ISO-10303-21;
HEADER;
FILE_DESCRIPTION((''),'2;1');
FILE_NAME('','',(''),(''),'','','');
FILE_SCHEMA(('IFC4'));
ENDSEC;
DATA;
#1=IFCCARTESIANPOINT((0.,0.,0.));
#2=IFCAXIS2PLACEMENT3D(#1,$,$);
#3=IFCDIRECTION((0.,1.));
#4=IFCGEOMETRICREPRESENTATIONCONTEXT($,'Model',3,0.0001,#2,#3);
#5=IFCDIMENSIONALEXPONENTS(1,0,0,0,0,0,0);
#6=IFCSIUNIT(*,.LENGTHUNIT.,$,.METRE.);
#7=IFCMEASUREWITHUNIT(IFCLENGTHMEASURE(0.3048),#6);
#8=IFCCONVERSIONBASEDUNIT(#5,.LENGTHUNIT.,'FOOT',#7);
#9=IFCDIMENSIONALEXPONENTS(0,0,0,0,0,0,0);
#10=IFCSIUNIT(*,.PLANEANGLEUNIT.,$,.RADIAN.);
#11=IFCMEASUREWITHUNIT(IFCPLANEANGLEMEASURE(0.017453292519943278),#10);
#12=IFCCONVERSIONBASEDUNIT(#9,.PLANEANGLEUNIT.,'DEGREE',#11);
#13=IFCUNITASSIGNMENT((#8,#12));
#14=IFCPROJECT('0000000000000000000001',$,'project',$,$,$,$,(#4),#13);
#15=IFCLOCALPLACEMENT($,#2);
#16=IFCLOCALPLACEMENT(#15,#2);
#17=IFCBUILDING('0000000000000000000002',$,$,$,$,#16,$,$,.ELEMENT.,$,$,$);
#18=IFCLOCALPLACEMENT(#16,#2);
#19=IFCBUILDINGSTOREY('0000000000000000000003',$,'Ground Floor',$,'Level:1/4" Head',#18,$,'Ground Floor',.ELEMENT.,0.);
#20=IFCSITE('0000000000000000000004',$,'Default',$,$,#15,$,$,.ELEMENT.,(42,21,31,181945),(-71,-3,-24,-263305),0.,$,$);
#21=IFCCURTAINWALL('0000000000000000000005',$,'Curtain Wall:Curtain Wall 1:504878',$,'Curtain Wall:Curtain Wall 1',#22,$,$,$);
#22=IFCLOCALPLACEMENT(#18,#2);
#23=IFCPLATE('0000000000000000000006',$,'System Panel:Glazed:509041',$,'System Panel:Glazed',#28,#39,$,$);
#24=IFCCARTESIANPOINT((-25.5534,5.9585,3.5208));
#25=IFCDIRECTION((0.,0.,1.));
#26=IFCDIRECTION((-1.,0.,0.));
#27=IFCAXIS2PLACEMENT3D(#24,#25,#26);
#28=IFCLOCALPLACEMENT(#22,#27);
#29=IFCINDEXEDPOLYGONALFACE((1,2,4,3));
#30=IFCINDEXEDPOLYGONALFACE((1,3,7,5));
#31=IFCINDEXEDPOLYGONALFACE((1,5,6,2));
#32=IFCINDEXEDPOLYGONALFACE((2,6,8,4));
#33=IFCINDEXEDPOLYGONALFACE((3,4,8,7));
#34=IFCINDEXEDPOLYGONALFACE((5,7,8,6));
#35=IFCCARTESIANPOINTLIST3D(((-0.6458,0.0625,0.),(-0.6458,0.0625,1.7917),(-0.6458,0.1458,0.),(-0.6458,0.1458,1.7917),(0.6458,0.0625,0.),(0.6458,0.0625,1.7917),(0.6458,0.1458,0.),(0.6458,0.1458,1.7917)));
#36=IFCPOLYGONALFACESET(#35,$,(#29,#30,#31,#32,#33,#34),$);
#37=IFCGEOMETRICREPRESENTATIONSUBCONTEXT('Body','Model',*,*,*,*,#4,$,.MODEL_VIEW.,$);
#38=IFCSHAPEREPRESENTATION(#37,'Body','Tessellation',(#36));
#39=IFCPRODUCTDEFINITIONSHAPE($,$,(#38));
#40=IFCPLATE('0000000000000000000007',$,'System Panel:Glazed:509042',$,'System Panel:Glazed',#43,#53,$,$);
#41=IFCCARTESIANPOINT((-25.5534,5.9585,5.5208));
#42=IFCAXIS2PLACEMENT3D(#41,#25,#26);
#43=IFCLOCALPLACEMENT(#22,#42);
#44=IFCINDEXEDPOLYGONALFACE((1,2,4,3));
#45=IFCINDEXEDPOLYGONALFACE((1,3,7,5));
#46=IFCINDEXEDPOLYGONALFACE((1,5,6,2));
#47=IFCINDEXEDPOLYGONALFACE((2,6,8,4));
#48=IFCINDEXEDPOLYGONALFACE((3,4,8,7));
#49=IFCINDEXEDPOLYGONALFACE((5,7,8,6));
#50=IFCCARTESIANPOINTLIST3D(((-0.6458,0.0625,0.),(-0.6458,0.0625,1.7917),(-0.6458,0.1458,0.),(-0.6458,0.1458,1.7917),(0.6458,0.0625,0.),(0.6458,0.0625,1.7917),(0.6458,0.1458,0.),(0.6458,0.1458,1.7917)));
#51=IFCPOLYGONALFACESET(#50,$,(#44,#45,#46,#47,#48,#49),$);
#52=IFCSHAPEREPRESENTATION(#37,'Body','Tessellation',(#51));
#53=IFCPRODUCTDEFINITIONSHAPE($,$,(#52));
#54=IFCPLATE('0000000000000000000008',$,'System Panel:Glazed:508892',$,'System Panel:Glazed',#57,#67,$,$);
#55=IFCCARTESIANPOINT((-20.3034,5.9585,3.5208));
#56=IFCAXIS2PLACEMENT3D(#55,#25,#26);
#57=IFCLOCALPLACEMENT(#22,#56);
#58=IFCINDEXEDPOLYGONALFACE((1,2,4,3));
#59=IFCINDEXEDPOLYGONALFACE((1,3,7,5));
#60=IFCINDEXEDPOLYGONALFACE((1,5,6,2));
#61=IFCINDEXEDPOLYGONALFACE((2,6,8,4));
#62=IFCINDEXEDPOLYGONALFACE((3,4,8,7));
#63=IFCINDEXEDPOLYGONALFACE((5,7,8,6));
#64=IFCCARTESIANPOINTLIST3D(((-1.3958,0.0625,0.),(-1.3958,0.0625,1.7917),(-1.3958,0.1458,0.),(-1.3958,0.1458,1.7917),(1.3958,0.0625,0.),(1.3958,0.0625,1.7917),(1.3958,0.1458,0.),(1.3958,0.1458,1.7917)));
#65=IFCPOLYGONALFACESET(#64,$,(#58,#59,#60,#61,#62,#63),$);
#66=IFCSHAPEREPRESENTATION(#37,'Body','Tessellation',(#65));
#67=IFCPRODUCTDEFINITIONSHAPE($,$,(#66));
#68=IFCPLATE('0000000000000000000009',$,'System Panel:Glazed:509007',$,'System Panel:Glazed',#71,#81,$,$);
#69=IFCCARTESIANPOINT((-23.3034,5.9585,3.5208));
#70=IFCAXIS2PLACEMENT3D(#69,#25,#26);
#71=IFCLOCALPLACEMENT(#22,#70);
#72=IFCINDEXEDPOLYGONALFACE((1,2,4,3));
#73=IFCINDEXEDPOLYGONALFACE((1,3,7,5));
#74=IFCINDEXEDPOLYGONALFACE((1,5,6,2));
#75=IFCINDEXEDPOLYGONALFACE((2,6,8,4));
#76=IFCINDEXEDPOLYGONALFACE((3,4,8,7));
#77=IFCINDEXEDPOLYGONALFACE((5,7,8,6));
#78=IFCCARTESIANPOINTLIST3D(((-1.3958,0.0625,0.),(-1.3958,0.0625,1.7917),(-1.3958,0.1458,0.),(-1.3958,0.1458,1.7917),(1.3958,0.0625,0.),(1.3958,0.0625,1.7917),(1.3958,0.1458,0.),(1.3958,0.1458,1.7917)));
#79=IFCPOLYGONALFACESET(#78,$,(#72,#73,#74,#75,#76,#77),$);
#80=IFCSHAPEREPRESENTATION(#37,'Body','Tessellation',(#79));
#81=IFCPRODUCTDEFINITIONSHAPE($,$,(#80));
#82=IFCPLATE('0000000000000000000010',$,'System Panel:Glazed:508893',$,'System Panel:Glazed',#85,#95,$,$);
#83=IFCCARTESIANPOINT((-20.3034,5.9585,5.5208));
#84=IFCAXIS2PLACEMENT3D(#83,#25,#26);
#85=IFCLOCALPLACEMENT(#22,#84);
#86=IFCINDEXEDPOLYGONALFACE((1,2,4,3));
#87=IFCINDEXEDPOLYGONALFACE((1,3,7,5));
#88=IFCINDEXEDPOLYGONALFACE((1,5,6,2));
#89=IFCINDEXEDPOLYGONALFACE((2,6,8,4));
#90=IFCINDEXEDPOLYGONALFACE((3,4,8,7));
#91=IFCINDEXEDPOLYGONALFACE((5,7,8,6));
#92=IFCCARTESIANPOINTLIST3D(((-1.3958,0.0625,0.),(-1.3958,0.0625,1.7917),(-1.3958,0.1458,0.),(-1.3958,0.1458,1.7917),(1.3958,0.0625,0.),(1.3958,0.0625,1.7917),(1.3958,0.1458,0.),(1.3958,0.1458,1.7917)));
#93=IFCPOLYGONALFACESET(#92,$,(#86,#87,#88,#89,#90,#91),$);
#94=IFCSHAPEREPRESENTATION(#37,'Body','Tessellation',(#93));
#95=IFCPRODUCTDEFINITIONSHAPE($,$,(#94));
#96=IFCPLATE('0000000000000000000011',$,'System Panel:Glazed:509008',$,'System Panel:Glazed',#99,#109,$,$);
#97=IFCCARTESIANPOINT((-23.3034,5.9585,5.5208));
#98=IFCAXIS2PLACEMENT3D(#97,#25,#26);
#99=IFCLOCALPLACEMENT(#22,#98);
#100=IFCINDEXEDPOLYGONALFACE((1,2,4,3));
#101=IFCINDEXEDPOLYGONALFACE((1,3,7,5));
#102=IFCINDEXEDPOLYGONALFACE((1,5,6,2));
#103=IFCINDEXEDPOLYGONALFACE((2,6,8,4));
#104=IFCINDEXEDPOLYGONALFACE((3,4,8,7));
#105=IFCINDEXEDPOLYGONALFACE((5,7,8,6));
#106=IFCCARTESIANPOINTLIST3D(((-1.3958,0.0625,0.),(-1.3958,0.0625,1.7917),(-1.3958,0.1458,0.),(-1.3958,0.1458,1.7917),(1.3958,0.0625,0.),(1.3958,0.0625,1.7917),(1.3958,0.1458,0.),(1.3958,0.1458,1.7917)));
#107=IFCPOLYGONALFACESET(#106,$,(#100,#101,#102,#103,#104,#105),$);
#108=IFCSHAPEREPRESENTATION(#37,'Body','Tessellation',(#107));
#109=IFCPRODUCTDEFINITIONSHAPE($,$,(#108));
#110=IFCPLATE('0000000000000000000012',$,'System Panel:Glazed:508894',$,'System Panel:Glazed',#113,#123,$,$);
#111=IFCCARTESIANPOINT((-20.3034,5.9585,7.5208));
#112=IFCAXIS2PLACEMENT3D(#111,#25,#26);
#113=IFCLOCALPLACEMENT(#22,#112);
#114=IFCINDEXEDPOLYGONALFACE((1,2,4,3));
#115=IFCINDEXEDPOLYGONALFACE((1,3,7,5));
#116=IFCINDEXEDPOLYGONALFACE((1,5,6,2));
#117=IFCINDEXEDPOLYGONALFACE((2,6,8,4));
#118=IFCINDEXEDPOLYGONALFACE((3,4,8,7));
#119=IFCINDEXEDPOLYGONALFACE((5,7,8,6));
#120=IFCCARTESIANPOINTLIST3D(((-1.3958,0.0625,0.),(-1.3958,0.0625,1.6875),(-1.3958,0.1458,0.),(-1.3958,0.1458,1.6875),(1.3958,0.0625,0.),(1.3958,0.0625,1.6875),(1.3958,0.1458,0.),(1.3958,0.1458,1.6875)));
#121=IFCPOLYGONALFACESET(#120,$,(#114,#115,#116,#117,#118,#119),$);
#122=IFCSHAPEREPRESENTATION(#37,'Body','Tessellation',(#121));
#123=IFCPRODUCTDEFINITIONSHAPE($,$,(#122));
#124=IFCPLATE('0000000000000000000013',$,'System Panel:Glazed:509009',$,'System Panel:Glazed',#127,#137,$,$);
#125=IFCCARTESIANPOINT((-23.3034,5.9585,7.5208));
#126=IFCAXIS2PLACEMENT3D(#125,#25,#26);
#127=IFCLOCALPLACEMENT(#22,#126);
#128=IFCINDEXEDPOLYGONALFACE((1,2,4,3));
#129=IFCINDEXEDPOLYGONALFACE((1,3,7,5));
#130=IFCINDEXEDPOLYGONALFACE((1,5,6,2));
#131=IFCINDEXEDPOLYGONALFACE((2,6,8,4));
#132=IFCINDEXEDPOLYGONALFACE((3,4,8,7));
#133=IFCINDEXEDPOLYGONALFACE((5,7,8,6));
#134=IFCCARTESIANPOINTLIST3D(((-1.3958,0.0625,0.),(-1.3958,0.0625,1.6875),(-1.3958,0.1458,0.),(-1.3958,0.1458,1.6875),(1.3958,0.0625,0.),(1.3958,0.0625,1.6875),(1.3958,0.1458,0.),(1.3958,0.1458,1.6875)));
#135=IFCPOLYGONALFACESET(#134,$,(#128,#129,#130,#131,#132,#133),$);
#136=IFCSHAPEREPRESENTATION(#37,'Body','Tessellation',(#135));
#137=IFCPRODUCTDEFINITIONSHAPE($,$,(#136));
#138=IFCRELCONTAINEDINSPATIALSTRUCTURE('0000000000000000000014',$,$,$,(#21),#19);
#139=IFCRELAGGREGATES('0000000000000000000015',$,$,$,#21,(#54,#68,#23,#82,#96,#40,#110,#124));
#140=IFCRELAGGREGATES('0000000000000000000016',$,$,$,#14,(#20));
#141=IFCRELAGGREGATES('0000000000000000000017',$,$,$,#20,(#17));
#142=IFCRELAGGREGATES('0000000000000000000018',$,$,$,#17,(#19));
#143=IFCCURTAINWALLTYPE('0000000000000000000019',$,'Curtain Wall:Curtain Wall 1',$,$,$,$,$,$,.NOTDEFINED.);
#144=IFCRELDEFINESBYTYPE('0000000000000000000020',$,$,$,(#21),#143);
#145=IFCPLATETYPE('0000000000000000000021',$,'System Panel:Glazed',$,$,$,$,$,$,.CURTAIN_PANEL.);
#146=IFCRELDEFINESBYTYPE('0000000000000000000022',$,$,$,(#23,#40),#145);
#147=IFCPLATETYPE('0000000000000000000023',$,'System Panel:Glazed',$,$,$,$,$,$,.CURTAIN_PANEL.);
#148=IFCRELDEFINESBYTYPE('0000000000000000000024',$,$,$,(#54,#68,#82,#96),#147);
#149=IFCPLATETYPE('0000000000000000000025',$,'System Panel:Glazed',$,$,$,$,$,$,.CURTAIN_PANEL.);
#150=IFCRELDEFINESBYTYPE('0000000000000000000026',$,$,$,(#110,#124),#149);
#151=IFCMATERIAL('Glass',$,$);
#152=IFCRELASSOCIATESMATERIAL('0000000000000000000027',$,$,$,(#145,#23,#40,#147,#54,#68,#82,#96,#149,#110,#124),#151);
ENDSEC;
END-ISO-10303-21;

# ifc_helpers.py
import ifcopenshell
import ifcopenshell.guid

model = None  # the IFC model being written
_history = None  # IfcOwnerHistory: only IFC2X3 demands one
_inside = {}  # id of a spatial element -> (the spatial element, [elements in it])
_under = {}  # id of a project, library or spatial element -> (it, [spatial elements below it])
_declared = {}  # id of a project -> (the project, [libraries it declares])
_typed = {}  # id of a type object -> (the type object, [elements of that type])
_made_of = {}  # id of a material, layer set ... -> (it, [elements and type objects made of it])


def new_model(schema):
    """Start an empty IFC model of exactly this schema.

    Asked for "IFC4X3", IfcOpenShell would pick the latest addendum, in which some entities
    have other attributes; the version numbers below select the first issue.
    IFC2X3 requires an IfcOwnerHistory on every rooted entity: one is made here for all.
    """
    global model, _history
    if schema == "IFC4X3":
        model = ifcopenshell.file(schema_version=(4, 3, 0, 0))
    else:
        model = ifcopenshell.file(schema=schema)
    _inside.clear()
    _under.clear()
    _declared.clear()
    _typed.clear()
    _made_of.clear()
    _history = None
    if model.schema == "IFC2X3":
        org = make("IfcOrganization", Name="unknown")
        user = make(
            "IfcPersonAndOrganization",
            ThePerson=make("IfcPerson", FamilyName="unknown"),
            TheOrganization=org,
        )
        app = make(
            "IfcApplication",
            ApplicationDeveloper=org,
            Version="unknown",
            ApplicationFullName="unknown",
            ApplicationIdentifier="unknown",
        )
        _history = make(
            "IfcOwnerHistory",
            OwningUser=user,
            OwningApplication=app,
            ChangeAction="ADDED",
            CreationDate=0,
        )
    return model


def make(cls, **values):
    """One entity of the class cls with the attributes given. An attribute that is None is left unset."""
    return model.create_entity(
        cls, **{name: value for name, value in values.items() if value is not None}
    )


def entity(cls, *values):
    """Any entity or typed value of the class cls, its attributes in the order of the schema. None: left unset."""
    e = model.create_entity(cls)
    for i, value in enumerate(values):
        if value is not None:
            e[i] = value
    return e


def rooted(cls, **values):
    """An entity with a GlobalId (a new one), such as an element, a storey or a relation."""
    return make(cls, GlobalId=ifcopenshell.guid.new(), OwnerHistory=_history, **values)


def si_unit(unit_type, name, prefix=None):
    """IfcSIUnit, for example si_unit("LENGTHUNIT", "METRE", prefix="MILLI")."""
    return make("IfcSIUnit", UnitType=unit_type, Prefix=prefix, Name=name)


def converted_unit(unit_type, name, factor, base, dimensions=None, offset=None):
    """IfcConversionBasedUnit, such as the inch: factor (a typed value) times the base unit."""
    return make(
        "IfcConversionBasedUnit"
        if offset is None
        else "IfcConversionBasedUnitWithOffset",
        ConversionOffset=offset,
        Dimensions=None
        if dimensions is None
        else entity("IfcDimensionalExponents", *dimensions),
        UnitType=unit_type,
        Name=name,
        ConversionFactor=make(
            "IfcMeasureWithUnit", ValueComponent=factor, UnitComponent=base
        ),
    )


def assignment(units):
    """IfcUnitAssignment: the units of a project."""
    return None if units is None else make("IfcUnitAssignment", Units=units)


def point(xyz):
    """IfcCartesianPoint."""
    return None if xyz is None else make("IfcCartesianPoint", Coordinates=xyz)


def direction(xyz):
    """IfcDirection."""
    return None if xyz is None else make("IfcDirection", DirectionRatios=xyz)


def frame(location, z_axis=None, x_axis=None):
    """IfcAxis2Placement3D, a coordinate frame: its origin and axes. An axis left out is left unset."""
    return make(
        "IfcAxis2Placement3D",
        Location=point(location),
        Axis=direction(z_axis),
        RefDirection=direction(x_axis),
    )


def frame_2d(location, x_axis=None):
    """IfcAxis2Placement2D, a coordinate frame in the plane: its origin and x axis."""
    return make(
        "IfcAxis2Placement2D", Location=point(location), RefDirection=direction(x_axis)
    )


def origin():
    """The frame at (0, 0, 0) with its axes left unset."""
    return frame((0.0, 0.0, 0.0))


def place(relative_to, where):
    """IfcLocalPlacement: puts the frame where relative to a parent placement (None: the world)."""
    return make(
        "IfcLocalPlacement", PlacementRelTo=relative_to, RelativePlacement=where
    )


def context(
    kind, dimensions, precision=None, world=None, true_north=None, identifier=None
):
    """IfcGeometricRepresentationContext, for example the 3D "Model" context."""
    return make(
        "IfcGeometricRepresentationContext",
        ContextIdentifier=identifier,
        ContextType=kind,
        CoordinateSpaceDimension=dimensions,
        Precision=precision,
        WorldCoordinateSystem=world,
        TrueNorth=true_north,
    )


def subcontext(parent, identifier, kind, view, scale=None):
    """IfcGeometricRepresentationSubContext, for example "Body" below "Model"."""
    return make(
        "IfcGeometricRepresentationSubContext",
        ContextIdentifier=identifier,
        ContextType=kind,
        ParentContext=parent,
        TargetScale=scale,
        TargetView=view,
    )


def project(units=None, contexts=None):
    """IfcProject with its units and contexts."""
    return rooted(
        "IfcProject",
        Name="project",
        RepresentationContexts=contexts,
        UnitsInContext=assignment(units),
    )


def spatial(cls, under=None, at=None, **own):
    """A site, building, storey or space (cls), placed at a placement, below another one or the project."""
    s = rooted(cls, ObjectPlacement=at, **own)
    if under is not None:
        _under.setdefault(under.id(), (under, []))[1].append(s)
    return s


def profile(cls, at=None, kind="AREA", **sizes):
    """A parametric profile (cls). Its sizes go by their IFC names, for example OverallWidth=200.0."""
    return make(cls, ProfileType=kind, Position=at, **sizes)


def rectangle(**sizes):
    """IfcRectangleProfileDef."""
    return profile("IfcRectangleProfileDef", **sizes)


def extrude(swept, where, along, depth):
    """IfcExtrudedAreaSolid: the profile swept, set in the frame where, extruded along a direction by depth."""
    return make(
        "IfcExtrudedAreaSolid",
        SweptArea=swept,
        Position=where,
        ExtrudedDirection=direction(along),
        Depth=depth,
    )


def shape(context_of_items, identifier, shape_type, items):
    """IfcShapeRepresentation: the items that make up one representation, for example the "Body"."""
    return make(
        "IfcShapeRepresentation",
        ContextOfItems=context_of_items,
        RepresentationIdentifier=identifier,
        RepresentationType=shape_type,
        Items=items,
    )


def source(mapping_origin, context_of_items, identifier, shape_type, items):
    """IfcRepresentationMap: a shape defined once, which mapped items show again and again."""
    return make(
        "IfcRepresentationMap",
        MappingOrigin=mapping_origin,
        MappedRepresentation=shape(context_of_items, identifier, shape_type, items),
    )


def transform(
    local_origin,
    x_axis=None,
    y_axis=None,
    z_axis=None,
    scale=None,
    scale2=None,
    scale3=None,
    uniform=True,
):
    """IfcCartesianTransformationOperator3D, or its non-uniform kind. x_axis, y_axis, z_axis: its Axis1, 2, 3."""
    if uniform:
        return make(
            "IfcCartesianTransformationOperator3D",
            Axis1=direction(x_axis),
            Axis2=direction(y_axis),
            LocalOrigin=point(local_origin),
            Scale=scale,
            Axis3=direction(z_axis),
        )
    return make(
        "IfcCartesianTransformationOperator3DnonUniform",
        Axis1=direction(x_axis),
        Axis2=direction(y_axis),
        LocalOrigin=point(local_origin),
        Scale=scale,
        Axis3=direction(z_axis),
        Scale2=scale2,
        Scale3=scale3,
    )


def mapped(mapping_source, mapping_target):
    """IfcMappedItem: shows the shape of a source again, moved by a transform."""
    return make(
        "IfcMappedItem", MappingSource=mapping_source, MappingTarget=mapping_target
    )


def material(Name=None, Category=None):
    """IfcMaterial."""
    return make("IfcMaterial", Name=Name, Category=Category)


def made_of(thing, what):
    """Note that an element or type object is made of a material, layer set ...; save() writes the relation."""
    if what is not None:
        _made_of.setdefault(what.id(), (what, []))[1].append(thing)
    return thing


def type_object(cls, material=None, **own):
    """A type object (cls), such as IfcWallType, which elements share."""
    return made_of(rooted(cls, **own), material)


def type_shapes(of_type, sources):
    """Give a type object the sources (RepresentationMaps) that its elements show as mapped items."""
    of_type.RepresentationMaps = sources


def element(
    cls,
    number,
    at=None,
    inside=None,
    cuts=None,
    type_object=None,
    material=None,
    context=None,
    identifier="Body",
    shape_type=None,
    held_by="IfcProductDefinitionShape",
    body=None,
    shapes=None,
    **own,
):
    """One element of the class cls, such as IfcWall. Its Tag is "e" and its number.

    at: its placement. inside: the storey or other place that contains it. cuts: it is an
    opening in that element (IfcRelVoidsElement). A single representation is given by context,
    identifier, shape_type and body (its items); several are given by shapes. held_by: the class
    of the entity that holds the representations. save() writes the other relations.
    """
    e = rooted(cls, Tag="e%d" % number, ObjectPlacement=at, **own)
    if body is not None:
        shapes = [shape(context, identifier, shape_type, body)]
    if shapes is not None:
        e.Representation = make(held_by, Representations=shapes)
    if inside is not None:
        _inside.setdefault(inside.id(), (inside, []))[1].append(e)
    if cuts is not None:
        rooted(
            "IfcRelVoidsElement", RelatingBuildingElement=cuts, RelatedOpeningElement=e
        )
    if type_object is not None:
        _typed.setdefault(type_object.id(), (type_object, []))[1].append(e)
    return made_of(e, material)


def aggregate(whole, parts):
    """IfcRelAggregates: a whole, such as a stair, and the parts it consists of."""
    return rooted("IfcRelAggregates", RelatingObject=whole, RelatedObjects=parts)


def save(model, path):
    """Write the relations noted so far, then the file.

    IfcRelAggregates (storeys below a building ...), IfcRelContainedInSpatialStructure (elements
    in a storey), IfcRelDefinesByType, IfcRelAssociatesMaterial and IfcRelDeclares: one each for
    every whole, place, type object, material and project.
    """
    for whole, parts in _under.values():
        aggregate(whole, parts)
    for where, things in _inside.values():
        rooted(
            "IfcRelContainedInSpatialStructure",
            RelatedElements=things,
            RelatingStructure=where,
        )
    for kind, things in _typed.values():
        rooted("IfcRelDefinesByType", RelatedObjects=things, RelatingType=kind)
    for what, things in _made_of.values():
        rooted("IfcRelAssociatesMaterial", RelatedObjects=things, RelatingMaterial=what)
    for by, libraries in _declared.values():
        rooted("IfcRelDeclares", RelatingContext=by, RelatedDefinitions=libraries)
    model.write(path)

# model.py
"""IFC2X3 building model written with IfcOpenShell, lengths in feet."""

from ifc_helpers import new_model, entity, si_unit, converted_unit, direction, frame, frame_2d, origin, place, context, subcontext, project, spatial, rectangle, extrude, source, transform, mapped, material, type_object, type_shapes, element, aggregate, save


model = new_model("IFC2X3")

# Units and contexts
model_context = context("Model", 3, precision=0.0001, world=origin(), true_north=direction((0.0, 1.0)))
body_context = subcontext(model_context, "Body", "Model", "MODEL_VIEW")
ifc_project = project(units=[converted_unit("LENGTHUNIT", "FOOT", entity("IfcLengthMeasure", 0.3048), si_unit("LENGTHUNIT", "METRE"), dimensions=[1, 0, 0, 0, 0, 0, 0]), converted_unit("PLANEANGLEUNIT", "DEGREE", entity("IfcPlaneAngleMeasure", 0.017453292519943278), si_unit("PLANEANGLEUNIT", "RADIAN"), dimensions=[0, 0, 0, 0, 0, 0, 0])], contexts=[model_context])

# Site, building, storey
site_placement = place(None, origin())
site = spatial("IfcSite", under=ifc_project, at=site_placement, Name="Default", CompositionType="ELEMENT", RefLatitude=(42, 21, 31, 181945), RefLongitude=(-71, -3, -24, -263305), RefElevation=0.0)
building_placement = place(site_placement, origin())
building = spatial("IfcBuilding", under=site, at=building_placement, CompositionType="ELEMENT")
storey_placement = place(building_placement, origin())
storey = spatial("IfcBuildingStorey", under=building, at=storey_placement, Name="Ground Floor", ObjectType="Level:1/4\" Head", LongName="Ground Floor", CompositionType="ELEMENT", Elevation=0.0)

# Curtain wall, plates
curtain_wall_type = type_object("IfcCurtainWallType", Name="Curtain Wall:Curtain Wall 1", PredefinedType="NOTDEFINED")
curtain_wall_placement = place(storey_placement, origin())
curtain_wall = element("IfcCurtainWall", 1, at=curtain_wall_placement, inside=storey, type_object=curtain_wall_type, Name="Curtain Wall:Curtain Wall 1:504878", ObjectType="Curtain Wall:Curtain Wall 1")
ifc_material_1 = material(Name="Glass")
plate_type_1 = type_object("IfcPlateType", Name="System Panel:Glazed", PredefinedType="CURTAIN_PANEL", material=ifc_material_1)
shared_shape_1 = source(origin(), body_context, "Body", "SweptSolid", [
    extrude(rectangle(XDim=0.0833, YDim=1.2917, at=frame_2d((0.0, 0.0), x_axis=(1.0, 0.0))), frame((0.0, 0.1042, 0.0), z_axis=(0.0, 0.0, 1.0), x_axis=(0.0, 1.0, 0.0)), (0.0, 0.0, 1.0), 1.7917),
])
type_shapes(plate_type_1, [shared_shape_1])
plate_1_placement = place(curtain_wall_placement, frame((-25.5534, 5.9585, 3.5208), z_axis=(0.0, 0.0, 1.0), x_axis=(-1.0, 0.0, 0.0)))
plate_1 = element("IfcPlate", 2, at=plate_1_placement, type_object=plate_type_1, material=ifc_material_1, Name="System Panel:Glazed:509041", ObjectType="System Panel:Glazed", context=body_context, shape_type="MappedRepresentation", body=[
    mapped(shared_shape_1, transform((0.0, 0.0, 0.0), scale=1.0)),
])
plate_2_placement = place(curtain_wall_placement, frame((-25.5534, 5.9585, 5.5208), z_axis=(0.0, 0.0, 1.0), x_axis=(-1.0, 0.0, 0.0)))
plate_2 = element("IfcPlate", 3, at=plate_2_placement, type_object=plate_type_1, material=ifc_material_1, Name="System Panel:Glazed:509042", ObjectType="System Panel:Glazed", context=body_context, shape_type="MappedRepresentation", body=[
    mapped(shared_shape_1, transform((0.0, 0.0, 0.0), scale=1.0)),
])
plate_type_2 = type_object("IfcPlateType", Name="System Panel:Glazed", PredefinedType="CURTAIN_PANEL", material=ifc_material_1)
shared_shape_2 = source(origin(), body_context, "Body", "SweptSolid", [
    extrude(rectangle(XDim=0.0833, YDim=2.7917, at=frame_2d((0.0, 0.0), x_axis=(1.0, 0.0))), frame((0.0, 0.1042, 0.0), z_axis=(0.0, 0.0, 1.0), x_axis=(0.0, 1.0, 0.0)), (0.0, 0.0, 1.0), 1.7917),
])
type_shapes(plate_type_2, [shared_shape_2])
plate_3_placement = place(curtain_wall_placement, frame((-20.3034, 5.9585, 3.5208), z_axis=(0.0, 0.0, 1.0), x_axis=(-1.0, 0.0, 0.0)))
plate_3 = element("IfcPlate", 4, at=plate_3_placement, type_object=plate_type_2, material=ifc_material_1, Name="System Panel:Glazed:508892", ObjectType="System Panel:Glazed", context=body_context, shape_type="MappedRepresentation", body=[
    mapped(shared_shape_2, transform((0.0, 0.0, 0.0), scale=1.0)),
])
plate_4_placement = place(curtain_wall_placement, frame((-23.3034, 5.9585, 3.5208), z_axis=(0.0, 0.0, 1.0), x_axis=(-1.0, 0.0, 0.0)))
plate_4 = element("IfcPlate", 5, at=plate_4_placement, type_object=plate_type_2, material=ifc_material_1, Name="System Panel:Glazed:509007", ObjectType="System Panel:Glazed", context=body_context, shape_type="MappedRepresentation", body=[
    mapped(shared_shape_2, transform((0.0, 0.0, 0.0), scale=1.0)),
])
plate_5_placement = place(curtain_wall_placement, frame((-20.3034, 5.9585, 5.5208), z_axis=(0.0, 0.0, 1.0), x_axis=(-1.0, 0.0, 0.0)))
plate_5 = element("IfcPlate", 6, at=plate_5_placement, type_object=plate_type_2, material=ifc_material_1, Name="System Panel:Glazed:508893", ObjectType="System Panel:Glazed", context=body_context, shape_type="MappedRepresentation", body=[
    mapped(shared_shape_2, transform((0.0, 0.0, 0.0), scale=1.0)),
])
plate_6_placement = place(curtain_wall_placement, frame((-23.3034, 5.9585, 5.5208), z_axis=(0.0, 0.0, 1.0), x_axis=(-1.0, 0.0, 0.0)))
plate_6 = element("IfcPlate", 7, at=plate_6_placement, type_object=plate_type_2, material=ifc_material_1, Name="System Panel:Glazed:509008", ObjectType="System Panel:Glazed", context=body_context, shape_type="MappedRepresentation", body=[
    mapped(shared_shape_2, transform((0.0, 0.0, 0.0), scale=1.0)),
])
plate_type_3 = type_object("IfcPlateType", Name="System Panel:Glazed", PredefinedType="CURTAIN_PANEL", material=ifc_material_1)
shared_shape_3 = source(origin(), body_context, "Body", "SweptSolid", [
    extrude(rectangle(XDim=0.0833, YDim=2.7917, at=frame_2d((0.0, 0.0), x_axis=(1.0, 0.0))), frame((0.0, 0.1042, 0.0), z_axis=(0.0, 0.0, 1.0), x_axis=(0.0, 1.0, 0.0)), (0.0, 0.0, 1.0), 1.6875),
])
type_shapes(plate_type_3, [shared_shape_3])
plate_7_placement = place(curtain_wall_placement, frame((-20.3034, 5.9585, 7.5208), z_axis=(0.0, 0.0, 1.0), x_axis=(-1.0, 0.0, 0.0)))
plate_7 = element("IfcPlate", 8, at=plate_7_placement, type_object=plate_type_3, material=ifc_material_1, Name="System Panel:Glazed:508894", ObjectType="System Panel:Glazed", context=body_context, shape_type="MappedRepresentation", body=[
    mapped(shared_shape_3, transform((0.0, 0.0, 0.0), scale=1.0)),
])
plate_8_placement = place(curtain_wall_placement, frame((-23.3034, 5.9585, 7.5208), z_axis=(0.0, 0.0, 1.0), x_axis=(-1.0, 0.0, 0.0)))
plate_8 = element("IfcPlate", 9, at=plate_8_placement, type_object=plate_type_3, material=ifc_material_1, Name="System Panel:Glazed:509009", ObjectType="System Panel:Glazed", context=body_context, shape_type="MappedRepresentation", body=[
    mapped(shared_shape_3, transform((0.0, 0.0, 0.0), scale=1.0)),
])
aggregate(curtain_wall, [plate_3, plate_4, plate_1, plate_5, plate_6, plate_2, plate_7, plate_8])

save(model, "model.ifc")
